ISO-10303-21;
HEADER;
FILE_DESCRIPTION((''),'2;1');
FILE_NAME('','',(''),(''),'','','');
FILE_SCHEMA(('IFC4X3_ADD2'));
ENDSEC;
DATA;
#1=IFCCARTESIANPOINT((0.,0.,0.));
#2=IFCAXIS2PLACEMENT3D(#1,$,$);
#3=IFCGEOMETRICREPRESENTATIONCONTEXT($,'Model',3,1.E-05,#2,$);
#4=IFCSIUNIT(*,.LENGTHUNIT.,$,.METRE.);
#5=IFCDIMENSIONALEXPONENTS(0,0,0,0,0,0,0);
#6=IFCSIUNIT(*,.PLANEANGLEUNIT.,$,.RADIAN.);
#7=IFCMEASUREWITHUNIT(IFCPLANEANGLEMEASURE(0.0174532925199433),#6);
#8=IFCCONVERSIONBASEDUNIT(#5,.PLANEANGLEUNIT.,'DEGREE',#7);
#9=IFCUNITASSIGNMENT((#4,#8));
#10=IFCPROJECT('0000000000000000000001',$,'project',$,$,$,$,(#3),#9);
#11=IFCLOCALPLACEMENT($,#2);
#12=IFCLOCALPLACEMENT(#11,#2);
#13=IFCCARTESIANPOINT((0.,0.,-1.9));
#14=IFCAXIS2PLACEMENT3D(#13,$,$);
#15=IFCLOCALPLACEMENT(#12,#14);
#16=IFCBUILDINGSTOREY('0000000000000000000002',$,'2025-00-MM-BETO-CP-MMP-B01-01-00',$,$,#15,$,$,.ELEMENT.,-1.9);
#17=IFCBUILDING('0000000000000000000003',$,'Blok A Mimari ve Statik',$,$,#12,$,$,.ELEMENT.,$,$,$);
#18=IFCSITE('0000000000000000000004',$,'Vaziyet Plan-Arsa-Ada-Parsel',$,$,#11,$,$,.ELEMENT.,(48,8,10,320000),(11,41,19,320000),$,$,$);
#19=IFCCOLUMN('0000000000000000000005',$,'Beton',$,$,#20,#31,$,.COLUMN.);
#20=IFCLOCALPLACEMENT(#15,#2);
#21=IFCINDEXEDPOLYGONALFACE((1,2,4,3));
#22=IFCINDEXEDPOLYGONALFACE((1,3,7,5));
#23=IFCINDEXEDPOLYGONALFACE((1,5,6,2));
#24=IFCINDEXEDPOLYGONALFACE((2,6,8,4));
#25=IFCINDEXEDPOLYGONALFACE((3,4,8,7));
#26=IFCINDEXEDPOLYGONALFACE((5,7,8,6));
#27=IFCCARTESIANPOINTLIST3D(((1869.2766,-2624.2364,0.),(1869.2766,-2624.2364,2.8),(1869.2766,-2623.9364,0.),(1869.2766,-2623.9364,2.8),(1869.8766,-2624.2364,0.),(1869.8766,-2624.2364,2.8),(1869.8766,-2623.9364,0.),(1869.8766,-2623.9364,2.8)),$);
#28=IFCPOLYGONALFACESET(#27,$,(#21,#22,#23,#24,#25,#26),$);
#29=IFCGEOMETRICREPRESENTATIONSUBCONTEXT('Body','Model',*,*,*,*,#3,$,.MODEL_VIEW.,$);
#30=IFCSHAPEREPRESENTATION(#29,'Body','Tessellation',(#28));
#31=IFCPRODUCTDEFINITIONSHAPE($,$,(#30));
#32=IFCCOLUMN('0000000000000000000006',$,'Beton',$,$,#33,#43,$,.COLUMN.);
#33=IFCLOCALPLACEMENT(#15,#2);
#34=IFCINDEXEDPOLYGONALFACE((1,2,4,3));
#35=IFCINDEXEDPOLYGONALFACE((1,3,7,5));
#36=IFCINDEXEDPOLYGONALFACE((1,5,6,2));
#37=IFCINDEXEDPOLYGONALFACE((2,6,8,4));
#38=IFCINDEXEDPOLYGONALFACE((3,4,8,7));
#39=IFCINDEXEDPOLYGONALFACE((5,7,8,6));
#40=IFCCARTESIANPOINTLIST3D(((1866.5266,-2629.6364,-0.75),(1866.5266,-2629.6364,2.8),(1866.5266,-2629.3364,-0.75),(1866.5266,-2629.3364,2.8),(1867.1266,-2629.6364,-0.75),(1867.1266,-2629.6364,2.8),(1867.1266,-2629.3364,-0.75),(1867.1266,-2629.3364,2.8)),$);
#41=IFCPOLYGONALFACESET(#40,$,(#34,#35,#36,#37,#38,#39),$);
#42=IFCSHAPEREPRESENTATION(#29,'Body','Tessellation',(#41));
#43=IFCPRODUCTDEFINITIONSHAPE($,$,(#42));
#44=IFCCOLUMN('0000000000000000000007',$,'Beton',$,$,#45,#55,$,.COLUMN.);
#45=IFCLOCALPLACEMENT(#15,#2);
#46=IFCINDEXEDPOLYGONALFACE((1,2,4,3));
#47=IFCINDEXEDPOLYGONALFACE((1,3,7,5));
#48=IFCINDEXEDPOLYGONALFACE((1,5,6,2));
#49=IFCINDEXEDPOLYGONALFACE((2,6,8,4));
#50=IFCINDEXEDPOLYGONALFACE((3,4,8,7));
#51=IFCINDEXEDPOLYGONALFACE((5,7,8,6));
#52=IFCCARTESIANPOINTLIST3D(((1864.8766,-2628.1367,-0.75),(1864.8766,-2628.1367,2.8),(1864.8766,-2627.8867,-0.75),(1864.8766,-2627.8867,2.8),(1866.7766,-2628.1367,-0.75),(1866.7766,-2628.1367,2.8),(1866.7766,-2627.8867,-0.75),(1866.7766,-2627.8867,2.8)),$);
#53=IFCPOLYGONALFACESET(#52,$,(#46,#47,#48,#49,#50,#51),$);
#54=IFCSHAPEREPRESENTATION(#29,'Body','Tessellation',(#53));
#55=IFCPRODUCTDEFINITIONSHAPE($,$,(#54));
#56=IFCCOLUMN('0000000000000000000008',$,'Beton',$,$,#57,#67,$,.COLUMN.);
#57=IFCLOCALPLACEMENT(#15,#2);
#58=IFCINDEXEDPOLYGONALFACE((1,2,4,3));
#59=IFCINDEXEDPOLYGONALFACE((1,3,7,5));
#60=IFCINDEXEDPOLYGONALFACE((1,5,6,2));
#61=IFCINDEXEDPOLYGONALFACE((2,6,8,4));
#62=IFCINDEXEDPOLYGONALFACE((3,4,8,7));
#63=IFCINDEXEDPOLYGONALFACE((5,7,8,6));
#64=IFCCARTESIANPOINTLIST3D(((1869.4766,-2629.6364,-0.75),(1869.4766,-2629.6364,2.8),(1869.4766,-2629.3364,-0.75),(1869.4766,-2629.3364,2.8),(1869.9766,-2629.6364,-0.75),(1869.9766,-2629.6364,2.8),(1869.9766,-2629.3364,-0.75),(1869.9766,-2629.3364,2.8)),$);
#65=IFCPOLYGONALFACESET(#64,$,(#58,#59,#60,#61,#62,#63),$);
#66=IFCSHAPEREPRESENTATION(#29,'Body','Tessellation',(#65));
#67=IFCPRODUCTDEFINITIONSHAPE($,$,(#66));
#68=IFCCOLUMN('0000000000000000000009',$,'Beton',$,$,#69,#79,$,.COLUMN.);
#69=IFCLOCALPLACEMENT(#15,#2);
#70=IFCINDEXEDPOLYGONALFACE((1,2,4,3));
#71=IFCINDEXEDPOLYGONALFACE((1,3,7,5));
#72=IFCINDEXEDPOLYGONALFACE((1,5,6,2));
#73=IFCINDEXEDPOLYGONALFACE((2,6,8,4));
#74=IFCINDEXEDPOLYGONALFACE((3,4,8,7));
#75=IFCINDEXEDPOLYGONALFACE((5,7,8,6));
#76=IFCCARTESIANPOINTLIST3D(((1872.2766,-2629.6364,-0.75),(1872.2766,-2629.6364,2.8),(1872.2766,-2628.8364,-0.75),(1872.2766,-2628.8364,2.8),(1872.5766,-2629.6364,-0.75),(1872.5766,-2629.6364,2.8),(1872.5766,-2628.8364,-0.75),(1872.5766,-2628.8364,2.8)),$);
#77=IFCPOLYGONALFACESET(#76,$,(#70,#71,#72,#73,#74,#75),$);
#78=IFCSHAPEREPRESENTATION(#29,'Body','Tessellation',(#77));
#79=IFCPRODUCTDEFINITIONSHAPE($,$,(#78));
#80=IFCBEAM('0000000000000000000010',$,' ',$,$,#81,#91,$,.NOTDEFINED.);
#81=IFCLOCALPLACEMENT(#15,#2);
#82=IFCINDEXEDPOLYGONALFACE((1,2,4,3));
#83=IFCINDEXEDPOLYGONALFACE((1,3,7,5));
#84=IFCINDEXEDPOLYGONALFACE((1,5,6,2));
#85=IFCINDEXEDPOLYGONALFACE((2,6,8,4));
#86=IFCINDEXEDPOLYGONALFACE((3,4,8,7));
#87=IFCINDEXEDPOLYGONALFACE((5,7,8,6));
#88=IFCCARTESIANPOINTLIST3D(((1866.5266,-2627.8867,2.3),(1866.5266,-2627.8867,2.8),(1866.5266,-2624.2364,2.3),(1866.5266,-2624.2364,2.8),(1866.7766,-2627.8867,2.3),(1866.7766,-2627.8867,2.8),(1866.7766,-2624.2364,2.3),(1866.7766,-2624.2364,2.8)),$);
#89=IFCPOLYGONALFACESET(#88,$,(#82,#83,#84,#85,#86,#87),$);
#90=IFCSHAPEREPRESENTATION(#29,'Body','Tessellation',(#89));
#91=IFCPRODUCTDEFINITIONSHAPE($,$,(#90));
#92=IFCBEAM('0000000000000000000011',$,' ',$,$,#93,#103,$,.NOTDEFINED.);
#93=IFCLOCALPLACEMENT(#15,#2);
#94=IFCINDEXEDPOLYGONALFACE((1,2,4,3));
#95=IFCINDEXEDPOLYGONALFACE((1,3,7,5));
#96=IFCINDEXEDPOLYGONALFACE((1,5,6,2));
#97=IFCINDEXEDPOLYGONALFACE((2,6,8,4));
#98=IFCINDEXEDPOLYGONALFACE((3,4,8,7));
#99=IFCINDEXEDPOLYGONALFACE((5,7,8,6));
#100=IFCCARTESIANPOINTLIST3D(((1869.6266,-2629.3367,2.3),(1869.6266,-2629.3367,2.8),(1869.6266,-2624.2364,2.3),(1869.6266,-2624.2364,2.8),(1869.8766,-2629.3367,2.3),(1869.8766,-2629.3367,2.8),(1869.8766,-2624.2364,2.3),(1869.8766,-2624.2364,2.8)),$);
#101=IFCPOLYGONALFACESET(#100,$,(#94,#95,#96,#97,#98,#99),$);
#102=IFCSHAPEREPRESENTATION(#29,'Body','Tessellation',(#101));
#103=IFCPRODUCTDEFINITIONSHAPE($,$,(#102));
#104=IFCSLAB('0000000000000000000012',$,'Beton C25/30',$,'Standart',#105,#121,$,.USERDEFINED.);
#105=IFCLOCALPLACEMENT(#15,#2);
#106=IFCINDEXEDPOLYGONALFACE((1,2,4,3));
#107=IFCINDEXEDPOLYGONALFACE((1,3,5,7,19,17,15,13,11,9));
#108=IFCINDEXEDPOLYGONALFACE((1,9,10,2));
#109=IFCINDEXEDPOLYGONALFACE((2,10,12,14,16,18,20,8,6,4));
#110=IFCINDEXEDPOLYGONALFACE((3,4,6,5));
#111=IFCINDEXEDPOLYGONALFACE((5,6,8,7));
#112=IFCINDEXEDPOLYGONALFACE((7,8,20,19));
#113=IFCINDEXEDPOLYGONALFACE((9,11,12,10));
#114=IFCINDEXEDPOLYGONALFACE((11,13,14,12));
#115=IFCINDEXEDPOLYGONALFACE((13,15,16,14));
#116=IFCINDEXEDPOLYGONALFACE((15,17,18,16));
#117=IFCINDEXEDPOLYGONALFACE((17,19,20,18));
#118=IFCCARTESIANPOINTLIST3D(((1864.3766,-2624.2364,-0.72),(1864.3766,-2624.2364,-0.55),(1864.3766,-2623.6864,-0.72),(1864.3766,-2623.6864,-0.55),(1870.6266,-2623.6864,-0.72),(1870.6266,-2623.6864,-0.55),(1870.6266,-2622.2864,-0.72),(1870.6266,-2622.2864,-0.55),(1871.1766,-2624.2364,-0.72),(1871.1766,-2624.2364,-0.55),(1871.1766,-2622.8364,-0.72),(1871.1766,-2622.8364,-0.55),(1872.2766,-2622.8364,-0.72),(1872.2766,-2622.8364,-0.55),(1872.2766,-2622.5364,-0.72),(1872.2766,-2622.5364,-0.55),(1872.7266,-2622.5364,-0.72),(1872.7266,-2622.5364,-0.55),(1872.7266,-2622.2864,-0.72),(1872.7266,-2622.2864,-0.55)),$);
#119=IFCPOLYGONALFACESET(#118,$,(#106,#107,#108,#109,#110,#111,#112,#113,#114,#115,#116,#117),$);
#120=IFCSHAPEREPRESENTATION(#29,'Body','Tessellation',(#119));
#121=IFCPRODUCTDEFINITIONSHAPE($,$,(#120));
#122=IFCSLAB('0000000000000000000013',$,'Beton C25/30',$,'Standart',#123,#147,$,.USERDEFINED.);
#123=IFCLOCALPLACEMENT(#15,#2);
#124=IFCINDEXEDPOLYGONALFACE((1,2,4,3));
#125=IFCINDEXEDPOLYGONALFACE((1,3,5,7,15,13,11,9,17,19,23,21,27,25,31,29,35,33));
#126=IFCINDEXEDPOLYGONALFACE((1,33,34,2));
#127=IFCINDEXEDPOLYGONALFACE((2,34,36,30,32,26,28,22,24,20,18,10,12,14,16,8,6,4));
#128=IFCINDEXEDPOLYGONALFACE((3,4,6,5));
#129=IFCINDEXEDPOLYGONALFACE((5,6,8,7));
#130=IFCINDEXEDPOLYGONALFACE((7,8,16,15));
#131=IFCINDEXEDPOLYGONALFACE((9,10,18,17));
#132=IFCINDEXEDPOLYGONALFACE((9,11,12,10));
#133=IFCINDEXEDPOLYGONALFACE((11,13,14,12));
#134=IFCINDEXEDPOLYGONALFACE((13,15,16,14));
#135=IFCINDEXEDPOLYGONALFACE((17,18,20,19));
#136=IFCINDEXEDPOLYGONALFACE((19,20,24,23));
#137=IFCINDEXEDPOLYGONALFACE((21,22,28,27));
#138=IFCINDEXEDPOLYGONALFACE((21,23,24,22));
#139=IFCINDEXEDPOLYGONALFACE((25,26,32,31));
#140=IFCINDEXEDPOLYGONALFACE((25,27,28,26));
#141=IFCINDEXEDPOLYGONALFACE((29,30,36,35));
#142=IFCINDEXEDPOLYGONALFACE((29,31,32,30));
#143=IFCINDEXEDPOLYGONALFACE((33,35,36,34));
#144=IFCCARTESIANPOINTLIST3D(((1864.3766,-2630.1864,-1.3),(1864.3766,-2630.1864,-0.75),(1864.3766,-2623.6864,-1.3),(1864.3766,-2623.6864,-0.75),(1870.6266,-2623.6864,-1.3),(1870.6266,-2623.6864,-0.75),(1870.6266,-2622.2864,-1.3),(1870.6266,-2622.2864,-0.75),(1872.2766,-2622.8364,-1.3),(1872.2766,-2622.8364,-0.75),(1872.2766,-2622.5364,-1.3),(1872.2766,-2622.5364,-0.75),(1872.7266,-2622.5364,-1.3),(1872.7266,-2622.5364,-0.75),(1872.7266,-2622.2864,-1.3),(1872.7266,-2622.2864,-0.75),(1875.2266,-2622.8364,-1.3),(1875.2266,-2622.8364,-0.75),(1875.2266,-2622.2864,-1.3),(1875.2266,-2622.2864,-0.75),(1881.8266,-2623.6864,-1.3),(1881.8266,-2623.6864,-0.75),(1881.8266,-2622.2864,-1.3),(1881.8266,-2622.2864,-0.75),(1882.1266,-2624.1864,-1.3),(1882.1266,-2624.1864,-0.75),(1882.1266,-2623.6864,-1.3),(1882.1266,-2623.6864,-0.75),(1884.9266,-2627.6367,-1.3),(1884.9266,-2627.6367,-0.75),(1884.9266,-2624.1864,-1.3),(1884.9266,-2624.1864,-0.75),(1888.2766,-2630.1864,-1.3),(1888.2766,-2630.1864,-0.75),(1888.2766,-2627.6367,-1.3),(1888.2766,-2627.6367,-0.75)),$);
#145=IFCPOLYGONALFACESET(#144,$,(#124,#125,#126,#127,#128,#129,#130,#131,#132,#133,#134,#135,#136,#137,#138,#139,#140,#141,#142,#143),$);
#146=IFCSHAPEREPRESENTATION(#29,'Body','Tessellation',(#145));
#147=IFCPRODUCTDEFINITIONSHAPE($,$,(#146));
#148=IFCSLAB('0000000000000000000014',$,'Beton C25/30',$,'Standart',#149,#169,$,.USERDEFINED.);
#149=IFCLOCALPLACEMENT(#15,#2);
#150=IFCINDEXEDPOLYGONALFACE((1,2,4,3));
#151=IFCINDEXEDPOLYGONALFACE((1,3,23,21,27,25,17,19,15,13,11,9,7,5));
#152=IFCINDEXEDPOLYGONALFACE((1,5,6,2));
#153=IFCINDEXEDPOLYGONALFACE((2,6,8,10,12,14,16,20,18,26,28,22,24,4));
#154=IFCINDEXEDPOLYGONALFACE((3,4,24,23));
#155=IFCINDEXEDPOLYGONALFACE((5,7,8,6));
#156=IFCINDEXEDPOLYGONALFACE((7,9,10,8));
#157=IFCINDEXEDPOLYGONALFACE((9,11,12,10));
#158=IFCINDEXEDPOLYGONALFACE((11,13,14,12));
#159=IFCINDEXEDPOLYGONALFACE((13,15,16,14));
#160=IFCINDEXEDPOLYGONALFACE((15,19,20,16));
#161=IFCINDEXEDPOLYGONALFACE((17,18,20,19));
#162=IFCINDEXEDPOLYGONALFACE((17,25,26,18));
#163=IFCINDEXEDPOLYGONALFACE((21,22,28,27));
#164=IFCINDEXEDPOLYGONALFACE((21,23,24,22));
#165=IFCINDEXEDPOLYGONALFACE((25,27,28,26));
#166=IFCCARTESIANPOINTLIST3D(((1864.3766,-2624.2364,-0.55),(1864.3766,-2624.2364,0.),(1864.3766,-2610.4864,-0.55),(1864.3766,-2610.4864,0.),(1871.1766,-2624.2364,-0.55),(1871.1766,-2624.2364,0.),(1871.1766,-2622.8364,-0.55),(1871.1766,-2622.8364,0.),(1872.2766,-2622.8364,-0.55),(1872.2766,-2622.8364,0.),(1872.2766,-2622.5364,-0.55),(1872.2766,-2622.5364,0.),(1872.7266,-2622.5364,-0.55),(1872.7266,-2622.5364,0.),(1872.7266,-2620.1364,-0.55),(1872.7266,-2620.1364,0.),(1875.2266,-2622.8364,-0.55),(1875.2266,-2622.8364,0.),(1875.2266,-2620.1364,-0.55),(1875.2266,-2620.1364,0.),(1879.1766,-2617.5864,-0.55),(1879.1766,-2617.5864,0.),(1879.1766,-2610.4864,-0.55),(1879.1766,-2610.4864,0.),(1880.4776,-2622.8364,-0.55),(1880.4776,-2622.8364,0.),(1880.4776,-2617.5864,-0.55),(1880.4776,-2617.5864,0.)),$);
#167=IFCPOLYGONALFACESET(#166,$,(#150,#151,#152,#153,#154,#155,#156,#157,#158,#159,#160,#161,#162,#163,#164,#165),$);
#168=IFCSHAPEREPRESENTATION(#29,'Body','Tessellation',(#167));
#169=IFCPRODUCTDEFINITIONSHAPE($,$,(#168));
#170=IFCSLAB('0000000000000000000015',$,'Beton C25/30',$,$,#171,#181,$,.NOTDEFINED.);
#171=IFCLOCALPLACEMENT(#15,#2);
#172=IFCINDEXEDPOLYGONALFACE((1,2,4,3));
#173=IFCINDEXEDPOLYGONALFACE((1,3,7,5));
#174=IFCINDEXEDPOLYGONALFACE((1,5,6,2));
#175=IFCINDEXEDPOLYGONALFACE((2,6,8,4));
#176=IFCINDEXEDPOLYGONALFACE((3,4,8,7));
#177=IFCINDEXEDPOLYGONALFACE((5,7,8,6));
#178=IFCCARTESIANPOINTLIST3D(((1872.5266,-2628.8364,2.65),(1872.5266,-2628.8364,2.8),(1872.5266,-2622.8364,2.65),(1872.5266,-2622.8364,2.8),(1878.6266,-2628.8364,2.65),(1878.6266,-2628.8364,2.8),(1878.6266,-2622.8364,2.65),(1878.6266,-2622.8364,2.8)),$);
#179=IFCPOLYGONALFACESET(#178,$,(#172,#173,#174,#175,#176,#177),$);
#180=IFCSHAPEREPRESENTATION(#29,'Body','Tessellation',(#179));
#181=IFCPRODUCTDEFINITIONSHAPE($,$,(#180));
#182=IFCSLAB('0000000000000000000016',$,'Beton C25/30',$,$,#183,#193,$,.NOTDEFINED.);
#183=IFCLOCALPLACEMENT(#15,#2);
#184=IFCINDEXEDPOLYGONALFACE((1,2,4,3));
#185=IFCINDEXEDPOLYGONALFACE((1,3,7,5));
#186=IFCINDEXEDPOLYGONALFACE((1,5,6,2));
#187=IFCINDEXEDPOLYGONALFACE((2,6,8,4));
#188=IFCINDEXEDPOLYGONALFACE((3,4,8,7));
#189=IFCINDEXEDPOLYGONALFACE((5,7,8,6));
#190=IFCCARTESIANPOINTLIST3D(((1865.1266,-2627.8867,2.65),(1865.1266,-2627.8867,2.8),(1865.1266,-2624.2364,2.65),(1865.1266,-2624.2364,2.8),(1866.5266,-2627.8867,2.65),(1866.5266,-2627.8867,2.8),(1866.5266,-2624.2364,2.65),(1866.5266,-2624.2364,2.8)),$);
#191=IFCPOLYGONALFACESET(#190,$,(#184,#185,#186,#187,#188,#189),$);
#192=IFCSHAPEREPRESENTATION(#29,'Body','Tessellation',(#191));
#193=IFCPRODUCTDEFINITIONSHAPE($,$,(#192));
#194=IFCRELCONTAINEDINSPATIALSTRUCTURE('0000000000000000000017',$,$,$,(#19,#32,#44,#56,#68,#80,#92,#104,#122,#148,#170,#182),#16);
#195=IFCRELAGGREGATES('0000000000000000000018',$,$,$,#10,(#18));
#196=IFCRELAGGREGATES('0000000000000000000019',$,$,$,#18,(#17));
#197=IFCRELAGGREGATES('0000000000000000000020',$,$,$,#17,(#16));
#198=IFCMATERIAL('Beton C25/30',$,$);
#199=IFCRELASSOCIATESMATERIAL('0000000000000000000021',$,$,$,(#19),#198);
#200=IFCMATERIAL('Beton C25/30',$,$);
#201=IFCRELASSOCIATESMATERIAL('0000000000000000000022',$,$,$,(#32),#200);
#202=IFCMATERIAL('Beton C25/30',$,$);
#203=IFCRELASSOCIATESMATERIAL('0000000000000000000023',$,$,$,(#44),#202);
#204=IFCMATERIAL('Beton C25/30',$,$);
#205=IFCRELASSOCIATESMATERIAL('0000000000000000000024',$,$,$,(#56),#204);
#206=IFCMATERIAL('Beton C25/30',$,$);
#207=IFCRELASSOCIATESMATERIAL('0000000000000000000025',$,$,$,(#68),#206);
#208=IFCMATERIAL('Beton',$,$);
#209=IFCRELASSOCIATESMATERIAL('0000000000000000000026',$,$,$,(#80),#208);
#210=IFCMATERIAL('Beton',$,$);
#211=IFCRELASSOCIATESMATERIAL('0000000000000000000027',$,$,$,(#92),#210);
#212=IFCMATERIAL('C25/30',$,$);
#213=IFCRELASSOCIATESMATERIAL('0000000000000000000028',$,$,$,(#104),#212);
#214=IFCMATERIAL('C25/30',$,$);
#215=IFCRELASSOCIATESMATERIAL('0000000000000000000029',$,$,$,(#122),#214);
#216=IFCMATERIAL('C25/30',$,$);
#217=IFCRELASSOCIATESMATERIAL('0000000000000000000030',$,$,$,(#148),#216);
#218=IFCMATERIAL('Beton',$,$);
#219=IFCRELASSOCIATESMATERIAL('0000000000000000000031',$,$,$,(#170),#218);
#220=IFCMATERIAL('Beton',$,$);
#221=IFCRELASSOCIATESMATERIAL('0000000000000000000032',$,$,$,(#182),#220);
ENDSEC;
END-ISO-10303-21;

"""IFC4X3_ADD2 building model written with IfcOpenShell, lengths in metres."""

from ifc_helpers import new_model, entity, si_unit, converted_unit, frame, frame_2d, origin, origin_with_axes, place, context, subcontext, project, spatial, polyline, rectangle, outline, extrude, material, element, save


model = new_model("IFC4X3_ADD2")

# Units and contexts
model_context = context("Model", 3, precision=1e-05, world=origin())
body_context = subcontext(model_context, "Body", "Model", "MODEL_VIEW")
ifc_project = project(units=[si_unit("LENGTHUNIT", "METRE"), converted_unit("PLANEANGLEUNIT", "DEGREE", entity("IfcPlaneAngleMeasure", 0.0174532925199433), si_unit("PLANEANGLEUNIT", "RADIAN"), dimensions=[0, 0, 0, 0, 0, 0, 0])], contexts=[model_context])

# Site, building, storey
site_placement = place(None, origin())
site = spatial("IfcSite", under=ifc_project, at=site_placement, Name="Vaziyet Plan-Arsa-Ada-Parsel", CompositionType="ELEMENT", RefLatitude=(48, 8, 10, 320000), RefLongitude=(11, 41, 19, 320000))
building_placement = place(site_placement, origin())
building = spatial("IfcBuilding", under=site, at=building_placement, Name="Blok A Mimari ve Statik", CompositionType="ELEMENT")
storey_placement = place(building_placement, frame((0.0, 0.0, -1.9)))
storey = spatial("IfcBuildingStorey", under=building, at=storey_placement, Name="2025-00-MM-BETO-CP-MMP-B01-01-00", CompositionType="ELEMENT", Elevation=-1.9)

# Columns
ifc_material_1 = material(Name="Beton C25/30")
column_1_placement = place(storey_placement, frame((1869.2766, -2624.2364, 0.0)))
element("IfcColumn", 1, at=column_1_placement, inside=storey, material=ifc_material_1, Name="Beton", PredefinedType="COLUMN", context=body_context, shape_type="SweptSolid", body=[
    extrude(outline(polyline([(0.0, 0.0), (0.6, 0.0), (0.6, 0.3), (0.0, 0.3), (0.0, 0.0)])), origin_with_axes(), (0.0, 0.0, 1.0), 2.8),
])
ifc_material_2 = material(Name="Beton C25/30")
column_2_placement = place(storey_placement, frame((1866.5266, -2629.6364, -0.75)))
element("IfcColumn", 2, at=column_2_placement, inside=storey, material=ifc_material_2, Name="Beton", PredefinedType="COLUMN", context=body_context, shape_type="SweptSolid", body=[
    extrude(outline(polyline([(0.0, 0.3), (0.0, 0.0), (0.6, 0.0), (0.6, 0.3), (0.0, 0.3)])), origin_with_axes(), (0.0, 0.0, 1.0), 3.55),
])
ifc_material_3 = material(Name="Beton C25/30")
column_3_placement = place(storey_placement, frame((1864.8766, -2628.1367, -0.75)))
element("IfcColumn", 3, at=column_3_placement, inside=storey, material=ifc_material_3, Name="Beton", PredefinedType="COLUMN", context=body_context, shape_type="SweptSolid", body=[
    extrude(outline(polyline([(1.9, 0.25), (0.0, 0.25), (0.0, 0.0), (1.9, 0.0), (1.9, 0.25)])), origin_with_axes(), (0.0, 0.0, 1.0), 3.55),
])
ifc_material_4 = material(Name="Beton C25/30")
column_4_placement = place(storey_placement, frame((1869.4766, -2629.6364, -0.75)))
element("IfcColumn", 4, at=column_4_placement, inside=storey, material=ifc_material_4, Name="Beton", PredefinedType="COLUMN", context=body_context, shape_type="SweptSolid", body=[
    extrude(outline(polyline([(0.0, 0.3), (0.0, 0.0), (0.5, 0.0), (0.5, 0.3), (0.0, 0.3)])), origin_with_axes(), (0.0, 0.0, 1.0), 3.55),
])
ifc_material_5 = material(Name="Beton C25/30")
column_5_placement = place(storey_placement, frame((1872.2766, -2629.6364, -0.75)))
element("IfcColumn", 5, at=column_5_placement, inside=storey, material=ifc_material_5, Name="Beton", PredefinedType="COLUMN", context=body_context, shape_type="SweptSolid", body=[
    extrude(outline(polyline([(0.0, 0.8), (0.0, 0.0), (0.3, 0.0), (0.3, 0.8), (0.0, 0.8)])), origin_with_axes(), (0.0, 0.0, 1.0), 3.55),
])

# Beams
ifc_material_6 = material(Name="Beton")
beam_1_placement = place(storey_placement, frame((1866.7766, -2627.8867, 2.3), z_axis=(0.0, 0.0, 1.0), x_axis=(0.0, 1.0, 0.0)))
element("IfcBeam", 6, at=beam_1_placement, inside=storey, material=ifc_material_6, Name=" ", PredefinedType="NOTDEFINED", context=body_context, shape_type="SweptSolid", body=[
    extrude(rectangle(XDim=0.25, YDim=0.5, at=frame_2d((0.125, 0.25), x_axis=(1.0, 0.0))), frame((0.0, 0.0, 0.0), z_axis=(1.0, 0.0, 0.0), x_axis=(0.0, 1.0, 0.0)), (0.0, 0.0, 1.0), 3.6503),
])
ifc_material_7 = material(Name="Beton")
beam_2_placement = place(storey_placement, frame((1869.8766, -2629.3367, 2.3), z_axis=(0.0, 0.0, 1.0), x_axis=(0.0, 1.0, 0.0)))
element("IfcBeam", 7, at=beam_2_placement, inside=storey, material=ifc_material_7, Name=" ", PredefinedType="NOTDEFINED", context=body_context, shape_type="SweptSolid", body=[
    extrude(rectangle(XDim=0.25, YDim=0.5, at=frame_2d((0.125, 0.25), x_axis=(1.0, 0.0))), frame((0.0, 0.0, 0.0), z_axis=(1.0, 0.0, 0.0), x_axis=(0.0, 1.0, 0.0)), (0.0, 0.0, 1.0), 5.1003),
])

# Slabs
ifc_material_8 = material(Name="C25/30")
slab_1_placement = place(storey_placement, frame((1864.3766, -2624.2364, -0.72)))
element("IfcSlab", 8, at=slab_1_placement, inside=storey, material=ifc_material_8, Name="Beton C25/30", ObjectType="Standart", PredefinedType="USERDEFINED", context=body_context, shape_type="SweptSolid", body=[
    extrude(outline(polyline([(0.0, 0.55), (0.0, 0.0), (6.8, 0.0), (6.8, 1.4), (7.9, 1.4), (7.9, 1.7), (8.35, 1.7), (8.35, 1.95), (6.25, 1.95), (6.25, 0.55), (0.0, 0.55)])), origin_with_axes(), (0.0, 0.0, 1.0), 0.17),
])
ifc_material_9 = material(Name="C25/30")
slab_2_placement = place(storey_placement, frame((1864.3766, -2630.1864, -1.3)))
element("IfcSlab", 9, at=slab_2_placement, inside=storey, material=ifc_material_9, Name="Beton C25/30", ObjectType="Standart", PredefinedType="USERDEFINED", context=body_context, shape_type="SweptSolid", body=[
    extrude(outline(polyline([(17.75, 6.5), (17.45, 6.5), (17.45, 7.9), (10.85, 7.9), (10.85, 7.35), (7.9, 7.35), (7.9, 7.65), (8.35, 7.65), (8.35, 7.9), (6.25, 7.9), (6.25, 6.5), (0.0, 6.5), (0.0, 0.0), (23.9, 0.0), (23.9, 2.5497), (20.55, 2.5497), (20.55, 6.0), (17.75, 6.0), (17.75, 6.5)])), origin_with_axes(), (0.0, 0.0, 1.0), 0.55),
])
ifc_material_10 = material(Name="C25/30")
slab_3_placement = place(storey_placement, frame((1864.3766, -2624.2364, -0.55)))
element("IfcSlab", 10, at=slab_3_placement, inside=storey, material=ifc_material_10, Name="Beton C25/30", ObjectType="Standart", PredefinedType="USERDEFINED", context=body_context, shape_type="SweptSolid", body=[
    extrude(outline(polyline([(0.0, 0.0), (6.8, 0.0), (6.8, 1.4), (7.9, 1.4), (7.9, 1.7), (8.35, 1.7), (8.35, 4.1), (10.85, 4.1), (10.85, 1.4), (16.101, 1.4), (16.101, 6.65), (14.8, 6.65), (14.8, 13.75), (0.0, 13.75), (0.0, 0.0)])), origin_with_axes(), (0.0, 0.0, 1.0), 0.55),
])
ifc_material_11 = material(Name="Beton")
slab_4_placement = place(storey_placement, frame((1872.5266, -2628.8364, 2.65)))
element("IfcSlab", 11, at=slab_4_placement, inside=storey, material=ifc_material_11, Name="Beton C25/30", PredefinedType="NOTDEFINED", context=body_context, shape_type="SweptSolid", body=[
    extrude(rectangle(XDim=6.0, YDim=6.1, at=frame_2d((3.05, -3.0), x_axis=(0.0, -1.0))), frame((0.0, 6.0, 0.0), z_axis=(0.0, 0.0, 1.0), x_axis=(1.0, 0.0, 0.0)), (0.0, 0.0, 1.0), 0.15),
])
ifc_material_12 = material(Name="Beton")
slab_5_placement = place(storey_placement, frame((1865.1266, -2627.8867, 2.65)))
element("IfcSlab", 12, at=slab_5_placement, inside=storey, material=ifc_material_12, Name="Beton C25/30", PredefinedType="NOTDEFINED", context=body_context, shape_type="SweptSolid", body=[
    extrude(outline(polyline([(0.0, 0.0), (1.4, 0.0), (1.4, 3.6503), (0.0, 3.6503), (0.0, 0.0)])), origin_with_axes(), (0.0, 0.0, 1.0), 0.15),
])

save(model, "model.ifc")
